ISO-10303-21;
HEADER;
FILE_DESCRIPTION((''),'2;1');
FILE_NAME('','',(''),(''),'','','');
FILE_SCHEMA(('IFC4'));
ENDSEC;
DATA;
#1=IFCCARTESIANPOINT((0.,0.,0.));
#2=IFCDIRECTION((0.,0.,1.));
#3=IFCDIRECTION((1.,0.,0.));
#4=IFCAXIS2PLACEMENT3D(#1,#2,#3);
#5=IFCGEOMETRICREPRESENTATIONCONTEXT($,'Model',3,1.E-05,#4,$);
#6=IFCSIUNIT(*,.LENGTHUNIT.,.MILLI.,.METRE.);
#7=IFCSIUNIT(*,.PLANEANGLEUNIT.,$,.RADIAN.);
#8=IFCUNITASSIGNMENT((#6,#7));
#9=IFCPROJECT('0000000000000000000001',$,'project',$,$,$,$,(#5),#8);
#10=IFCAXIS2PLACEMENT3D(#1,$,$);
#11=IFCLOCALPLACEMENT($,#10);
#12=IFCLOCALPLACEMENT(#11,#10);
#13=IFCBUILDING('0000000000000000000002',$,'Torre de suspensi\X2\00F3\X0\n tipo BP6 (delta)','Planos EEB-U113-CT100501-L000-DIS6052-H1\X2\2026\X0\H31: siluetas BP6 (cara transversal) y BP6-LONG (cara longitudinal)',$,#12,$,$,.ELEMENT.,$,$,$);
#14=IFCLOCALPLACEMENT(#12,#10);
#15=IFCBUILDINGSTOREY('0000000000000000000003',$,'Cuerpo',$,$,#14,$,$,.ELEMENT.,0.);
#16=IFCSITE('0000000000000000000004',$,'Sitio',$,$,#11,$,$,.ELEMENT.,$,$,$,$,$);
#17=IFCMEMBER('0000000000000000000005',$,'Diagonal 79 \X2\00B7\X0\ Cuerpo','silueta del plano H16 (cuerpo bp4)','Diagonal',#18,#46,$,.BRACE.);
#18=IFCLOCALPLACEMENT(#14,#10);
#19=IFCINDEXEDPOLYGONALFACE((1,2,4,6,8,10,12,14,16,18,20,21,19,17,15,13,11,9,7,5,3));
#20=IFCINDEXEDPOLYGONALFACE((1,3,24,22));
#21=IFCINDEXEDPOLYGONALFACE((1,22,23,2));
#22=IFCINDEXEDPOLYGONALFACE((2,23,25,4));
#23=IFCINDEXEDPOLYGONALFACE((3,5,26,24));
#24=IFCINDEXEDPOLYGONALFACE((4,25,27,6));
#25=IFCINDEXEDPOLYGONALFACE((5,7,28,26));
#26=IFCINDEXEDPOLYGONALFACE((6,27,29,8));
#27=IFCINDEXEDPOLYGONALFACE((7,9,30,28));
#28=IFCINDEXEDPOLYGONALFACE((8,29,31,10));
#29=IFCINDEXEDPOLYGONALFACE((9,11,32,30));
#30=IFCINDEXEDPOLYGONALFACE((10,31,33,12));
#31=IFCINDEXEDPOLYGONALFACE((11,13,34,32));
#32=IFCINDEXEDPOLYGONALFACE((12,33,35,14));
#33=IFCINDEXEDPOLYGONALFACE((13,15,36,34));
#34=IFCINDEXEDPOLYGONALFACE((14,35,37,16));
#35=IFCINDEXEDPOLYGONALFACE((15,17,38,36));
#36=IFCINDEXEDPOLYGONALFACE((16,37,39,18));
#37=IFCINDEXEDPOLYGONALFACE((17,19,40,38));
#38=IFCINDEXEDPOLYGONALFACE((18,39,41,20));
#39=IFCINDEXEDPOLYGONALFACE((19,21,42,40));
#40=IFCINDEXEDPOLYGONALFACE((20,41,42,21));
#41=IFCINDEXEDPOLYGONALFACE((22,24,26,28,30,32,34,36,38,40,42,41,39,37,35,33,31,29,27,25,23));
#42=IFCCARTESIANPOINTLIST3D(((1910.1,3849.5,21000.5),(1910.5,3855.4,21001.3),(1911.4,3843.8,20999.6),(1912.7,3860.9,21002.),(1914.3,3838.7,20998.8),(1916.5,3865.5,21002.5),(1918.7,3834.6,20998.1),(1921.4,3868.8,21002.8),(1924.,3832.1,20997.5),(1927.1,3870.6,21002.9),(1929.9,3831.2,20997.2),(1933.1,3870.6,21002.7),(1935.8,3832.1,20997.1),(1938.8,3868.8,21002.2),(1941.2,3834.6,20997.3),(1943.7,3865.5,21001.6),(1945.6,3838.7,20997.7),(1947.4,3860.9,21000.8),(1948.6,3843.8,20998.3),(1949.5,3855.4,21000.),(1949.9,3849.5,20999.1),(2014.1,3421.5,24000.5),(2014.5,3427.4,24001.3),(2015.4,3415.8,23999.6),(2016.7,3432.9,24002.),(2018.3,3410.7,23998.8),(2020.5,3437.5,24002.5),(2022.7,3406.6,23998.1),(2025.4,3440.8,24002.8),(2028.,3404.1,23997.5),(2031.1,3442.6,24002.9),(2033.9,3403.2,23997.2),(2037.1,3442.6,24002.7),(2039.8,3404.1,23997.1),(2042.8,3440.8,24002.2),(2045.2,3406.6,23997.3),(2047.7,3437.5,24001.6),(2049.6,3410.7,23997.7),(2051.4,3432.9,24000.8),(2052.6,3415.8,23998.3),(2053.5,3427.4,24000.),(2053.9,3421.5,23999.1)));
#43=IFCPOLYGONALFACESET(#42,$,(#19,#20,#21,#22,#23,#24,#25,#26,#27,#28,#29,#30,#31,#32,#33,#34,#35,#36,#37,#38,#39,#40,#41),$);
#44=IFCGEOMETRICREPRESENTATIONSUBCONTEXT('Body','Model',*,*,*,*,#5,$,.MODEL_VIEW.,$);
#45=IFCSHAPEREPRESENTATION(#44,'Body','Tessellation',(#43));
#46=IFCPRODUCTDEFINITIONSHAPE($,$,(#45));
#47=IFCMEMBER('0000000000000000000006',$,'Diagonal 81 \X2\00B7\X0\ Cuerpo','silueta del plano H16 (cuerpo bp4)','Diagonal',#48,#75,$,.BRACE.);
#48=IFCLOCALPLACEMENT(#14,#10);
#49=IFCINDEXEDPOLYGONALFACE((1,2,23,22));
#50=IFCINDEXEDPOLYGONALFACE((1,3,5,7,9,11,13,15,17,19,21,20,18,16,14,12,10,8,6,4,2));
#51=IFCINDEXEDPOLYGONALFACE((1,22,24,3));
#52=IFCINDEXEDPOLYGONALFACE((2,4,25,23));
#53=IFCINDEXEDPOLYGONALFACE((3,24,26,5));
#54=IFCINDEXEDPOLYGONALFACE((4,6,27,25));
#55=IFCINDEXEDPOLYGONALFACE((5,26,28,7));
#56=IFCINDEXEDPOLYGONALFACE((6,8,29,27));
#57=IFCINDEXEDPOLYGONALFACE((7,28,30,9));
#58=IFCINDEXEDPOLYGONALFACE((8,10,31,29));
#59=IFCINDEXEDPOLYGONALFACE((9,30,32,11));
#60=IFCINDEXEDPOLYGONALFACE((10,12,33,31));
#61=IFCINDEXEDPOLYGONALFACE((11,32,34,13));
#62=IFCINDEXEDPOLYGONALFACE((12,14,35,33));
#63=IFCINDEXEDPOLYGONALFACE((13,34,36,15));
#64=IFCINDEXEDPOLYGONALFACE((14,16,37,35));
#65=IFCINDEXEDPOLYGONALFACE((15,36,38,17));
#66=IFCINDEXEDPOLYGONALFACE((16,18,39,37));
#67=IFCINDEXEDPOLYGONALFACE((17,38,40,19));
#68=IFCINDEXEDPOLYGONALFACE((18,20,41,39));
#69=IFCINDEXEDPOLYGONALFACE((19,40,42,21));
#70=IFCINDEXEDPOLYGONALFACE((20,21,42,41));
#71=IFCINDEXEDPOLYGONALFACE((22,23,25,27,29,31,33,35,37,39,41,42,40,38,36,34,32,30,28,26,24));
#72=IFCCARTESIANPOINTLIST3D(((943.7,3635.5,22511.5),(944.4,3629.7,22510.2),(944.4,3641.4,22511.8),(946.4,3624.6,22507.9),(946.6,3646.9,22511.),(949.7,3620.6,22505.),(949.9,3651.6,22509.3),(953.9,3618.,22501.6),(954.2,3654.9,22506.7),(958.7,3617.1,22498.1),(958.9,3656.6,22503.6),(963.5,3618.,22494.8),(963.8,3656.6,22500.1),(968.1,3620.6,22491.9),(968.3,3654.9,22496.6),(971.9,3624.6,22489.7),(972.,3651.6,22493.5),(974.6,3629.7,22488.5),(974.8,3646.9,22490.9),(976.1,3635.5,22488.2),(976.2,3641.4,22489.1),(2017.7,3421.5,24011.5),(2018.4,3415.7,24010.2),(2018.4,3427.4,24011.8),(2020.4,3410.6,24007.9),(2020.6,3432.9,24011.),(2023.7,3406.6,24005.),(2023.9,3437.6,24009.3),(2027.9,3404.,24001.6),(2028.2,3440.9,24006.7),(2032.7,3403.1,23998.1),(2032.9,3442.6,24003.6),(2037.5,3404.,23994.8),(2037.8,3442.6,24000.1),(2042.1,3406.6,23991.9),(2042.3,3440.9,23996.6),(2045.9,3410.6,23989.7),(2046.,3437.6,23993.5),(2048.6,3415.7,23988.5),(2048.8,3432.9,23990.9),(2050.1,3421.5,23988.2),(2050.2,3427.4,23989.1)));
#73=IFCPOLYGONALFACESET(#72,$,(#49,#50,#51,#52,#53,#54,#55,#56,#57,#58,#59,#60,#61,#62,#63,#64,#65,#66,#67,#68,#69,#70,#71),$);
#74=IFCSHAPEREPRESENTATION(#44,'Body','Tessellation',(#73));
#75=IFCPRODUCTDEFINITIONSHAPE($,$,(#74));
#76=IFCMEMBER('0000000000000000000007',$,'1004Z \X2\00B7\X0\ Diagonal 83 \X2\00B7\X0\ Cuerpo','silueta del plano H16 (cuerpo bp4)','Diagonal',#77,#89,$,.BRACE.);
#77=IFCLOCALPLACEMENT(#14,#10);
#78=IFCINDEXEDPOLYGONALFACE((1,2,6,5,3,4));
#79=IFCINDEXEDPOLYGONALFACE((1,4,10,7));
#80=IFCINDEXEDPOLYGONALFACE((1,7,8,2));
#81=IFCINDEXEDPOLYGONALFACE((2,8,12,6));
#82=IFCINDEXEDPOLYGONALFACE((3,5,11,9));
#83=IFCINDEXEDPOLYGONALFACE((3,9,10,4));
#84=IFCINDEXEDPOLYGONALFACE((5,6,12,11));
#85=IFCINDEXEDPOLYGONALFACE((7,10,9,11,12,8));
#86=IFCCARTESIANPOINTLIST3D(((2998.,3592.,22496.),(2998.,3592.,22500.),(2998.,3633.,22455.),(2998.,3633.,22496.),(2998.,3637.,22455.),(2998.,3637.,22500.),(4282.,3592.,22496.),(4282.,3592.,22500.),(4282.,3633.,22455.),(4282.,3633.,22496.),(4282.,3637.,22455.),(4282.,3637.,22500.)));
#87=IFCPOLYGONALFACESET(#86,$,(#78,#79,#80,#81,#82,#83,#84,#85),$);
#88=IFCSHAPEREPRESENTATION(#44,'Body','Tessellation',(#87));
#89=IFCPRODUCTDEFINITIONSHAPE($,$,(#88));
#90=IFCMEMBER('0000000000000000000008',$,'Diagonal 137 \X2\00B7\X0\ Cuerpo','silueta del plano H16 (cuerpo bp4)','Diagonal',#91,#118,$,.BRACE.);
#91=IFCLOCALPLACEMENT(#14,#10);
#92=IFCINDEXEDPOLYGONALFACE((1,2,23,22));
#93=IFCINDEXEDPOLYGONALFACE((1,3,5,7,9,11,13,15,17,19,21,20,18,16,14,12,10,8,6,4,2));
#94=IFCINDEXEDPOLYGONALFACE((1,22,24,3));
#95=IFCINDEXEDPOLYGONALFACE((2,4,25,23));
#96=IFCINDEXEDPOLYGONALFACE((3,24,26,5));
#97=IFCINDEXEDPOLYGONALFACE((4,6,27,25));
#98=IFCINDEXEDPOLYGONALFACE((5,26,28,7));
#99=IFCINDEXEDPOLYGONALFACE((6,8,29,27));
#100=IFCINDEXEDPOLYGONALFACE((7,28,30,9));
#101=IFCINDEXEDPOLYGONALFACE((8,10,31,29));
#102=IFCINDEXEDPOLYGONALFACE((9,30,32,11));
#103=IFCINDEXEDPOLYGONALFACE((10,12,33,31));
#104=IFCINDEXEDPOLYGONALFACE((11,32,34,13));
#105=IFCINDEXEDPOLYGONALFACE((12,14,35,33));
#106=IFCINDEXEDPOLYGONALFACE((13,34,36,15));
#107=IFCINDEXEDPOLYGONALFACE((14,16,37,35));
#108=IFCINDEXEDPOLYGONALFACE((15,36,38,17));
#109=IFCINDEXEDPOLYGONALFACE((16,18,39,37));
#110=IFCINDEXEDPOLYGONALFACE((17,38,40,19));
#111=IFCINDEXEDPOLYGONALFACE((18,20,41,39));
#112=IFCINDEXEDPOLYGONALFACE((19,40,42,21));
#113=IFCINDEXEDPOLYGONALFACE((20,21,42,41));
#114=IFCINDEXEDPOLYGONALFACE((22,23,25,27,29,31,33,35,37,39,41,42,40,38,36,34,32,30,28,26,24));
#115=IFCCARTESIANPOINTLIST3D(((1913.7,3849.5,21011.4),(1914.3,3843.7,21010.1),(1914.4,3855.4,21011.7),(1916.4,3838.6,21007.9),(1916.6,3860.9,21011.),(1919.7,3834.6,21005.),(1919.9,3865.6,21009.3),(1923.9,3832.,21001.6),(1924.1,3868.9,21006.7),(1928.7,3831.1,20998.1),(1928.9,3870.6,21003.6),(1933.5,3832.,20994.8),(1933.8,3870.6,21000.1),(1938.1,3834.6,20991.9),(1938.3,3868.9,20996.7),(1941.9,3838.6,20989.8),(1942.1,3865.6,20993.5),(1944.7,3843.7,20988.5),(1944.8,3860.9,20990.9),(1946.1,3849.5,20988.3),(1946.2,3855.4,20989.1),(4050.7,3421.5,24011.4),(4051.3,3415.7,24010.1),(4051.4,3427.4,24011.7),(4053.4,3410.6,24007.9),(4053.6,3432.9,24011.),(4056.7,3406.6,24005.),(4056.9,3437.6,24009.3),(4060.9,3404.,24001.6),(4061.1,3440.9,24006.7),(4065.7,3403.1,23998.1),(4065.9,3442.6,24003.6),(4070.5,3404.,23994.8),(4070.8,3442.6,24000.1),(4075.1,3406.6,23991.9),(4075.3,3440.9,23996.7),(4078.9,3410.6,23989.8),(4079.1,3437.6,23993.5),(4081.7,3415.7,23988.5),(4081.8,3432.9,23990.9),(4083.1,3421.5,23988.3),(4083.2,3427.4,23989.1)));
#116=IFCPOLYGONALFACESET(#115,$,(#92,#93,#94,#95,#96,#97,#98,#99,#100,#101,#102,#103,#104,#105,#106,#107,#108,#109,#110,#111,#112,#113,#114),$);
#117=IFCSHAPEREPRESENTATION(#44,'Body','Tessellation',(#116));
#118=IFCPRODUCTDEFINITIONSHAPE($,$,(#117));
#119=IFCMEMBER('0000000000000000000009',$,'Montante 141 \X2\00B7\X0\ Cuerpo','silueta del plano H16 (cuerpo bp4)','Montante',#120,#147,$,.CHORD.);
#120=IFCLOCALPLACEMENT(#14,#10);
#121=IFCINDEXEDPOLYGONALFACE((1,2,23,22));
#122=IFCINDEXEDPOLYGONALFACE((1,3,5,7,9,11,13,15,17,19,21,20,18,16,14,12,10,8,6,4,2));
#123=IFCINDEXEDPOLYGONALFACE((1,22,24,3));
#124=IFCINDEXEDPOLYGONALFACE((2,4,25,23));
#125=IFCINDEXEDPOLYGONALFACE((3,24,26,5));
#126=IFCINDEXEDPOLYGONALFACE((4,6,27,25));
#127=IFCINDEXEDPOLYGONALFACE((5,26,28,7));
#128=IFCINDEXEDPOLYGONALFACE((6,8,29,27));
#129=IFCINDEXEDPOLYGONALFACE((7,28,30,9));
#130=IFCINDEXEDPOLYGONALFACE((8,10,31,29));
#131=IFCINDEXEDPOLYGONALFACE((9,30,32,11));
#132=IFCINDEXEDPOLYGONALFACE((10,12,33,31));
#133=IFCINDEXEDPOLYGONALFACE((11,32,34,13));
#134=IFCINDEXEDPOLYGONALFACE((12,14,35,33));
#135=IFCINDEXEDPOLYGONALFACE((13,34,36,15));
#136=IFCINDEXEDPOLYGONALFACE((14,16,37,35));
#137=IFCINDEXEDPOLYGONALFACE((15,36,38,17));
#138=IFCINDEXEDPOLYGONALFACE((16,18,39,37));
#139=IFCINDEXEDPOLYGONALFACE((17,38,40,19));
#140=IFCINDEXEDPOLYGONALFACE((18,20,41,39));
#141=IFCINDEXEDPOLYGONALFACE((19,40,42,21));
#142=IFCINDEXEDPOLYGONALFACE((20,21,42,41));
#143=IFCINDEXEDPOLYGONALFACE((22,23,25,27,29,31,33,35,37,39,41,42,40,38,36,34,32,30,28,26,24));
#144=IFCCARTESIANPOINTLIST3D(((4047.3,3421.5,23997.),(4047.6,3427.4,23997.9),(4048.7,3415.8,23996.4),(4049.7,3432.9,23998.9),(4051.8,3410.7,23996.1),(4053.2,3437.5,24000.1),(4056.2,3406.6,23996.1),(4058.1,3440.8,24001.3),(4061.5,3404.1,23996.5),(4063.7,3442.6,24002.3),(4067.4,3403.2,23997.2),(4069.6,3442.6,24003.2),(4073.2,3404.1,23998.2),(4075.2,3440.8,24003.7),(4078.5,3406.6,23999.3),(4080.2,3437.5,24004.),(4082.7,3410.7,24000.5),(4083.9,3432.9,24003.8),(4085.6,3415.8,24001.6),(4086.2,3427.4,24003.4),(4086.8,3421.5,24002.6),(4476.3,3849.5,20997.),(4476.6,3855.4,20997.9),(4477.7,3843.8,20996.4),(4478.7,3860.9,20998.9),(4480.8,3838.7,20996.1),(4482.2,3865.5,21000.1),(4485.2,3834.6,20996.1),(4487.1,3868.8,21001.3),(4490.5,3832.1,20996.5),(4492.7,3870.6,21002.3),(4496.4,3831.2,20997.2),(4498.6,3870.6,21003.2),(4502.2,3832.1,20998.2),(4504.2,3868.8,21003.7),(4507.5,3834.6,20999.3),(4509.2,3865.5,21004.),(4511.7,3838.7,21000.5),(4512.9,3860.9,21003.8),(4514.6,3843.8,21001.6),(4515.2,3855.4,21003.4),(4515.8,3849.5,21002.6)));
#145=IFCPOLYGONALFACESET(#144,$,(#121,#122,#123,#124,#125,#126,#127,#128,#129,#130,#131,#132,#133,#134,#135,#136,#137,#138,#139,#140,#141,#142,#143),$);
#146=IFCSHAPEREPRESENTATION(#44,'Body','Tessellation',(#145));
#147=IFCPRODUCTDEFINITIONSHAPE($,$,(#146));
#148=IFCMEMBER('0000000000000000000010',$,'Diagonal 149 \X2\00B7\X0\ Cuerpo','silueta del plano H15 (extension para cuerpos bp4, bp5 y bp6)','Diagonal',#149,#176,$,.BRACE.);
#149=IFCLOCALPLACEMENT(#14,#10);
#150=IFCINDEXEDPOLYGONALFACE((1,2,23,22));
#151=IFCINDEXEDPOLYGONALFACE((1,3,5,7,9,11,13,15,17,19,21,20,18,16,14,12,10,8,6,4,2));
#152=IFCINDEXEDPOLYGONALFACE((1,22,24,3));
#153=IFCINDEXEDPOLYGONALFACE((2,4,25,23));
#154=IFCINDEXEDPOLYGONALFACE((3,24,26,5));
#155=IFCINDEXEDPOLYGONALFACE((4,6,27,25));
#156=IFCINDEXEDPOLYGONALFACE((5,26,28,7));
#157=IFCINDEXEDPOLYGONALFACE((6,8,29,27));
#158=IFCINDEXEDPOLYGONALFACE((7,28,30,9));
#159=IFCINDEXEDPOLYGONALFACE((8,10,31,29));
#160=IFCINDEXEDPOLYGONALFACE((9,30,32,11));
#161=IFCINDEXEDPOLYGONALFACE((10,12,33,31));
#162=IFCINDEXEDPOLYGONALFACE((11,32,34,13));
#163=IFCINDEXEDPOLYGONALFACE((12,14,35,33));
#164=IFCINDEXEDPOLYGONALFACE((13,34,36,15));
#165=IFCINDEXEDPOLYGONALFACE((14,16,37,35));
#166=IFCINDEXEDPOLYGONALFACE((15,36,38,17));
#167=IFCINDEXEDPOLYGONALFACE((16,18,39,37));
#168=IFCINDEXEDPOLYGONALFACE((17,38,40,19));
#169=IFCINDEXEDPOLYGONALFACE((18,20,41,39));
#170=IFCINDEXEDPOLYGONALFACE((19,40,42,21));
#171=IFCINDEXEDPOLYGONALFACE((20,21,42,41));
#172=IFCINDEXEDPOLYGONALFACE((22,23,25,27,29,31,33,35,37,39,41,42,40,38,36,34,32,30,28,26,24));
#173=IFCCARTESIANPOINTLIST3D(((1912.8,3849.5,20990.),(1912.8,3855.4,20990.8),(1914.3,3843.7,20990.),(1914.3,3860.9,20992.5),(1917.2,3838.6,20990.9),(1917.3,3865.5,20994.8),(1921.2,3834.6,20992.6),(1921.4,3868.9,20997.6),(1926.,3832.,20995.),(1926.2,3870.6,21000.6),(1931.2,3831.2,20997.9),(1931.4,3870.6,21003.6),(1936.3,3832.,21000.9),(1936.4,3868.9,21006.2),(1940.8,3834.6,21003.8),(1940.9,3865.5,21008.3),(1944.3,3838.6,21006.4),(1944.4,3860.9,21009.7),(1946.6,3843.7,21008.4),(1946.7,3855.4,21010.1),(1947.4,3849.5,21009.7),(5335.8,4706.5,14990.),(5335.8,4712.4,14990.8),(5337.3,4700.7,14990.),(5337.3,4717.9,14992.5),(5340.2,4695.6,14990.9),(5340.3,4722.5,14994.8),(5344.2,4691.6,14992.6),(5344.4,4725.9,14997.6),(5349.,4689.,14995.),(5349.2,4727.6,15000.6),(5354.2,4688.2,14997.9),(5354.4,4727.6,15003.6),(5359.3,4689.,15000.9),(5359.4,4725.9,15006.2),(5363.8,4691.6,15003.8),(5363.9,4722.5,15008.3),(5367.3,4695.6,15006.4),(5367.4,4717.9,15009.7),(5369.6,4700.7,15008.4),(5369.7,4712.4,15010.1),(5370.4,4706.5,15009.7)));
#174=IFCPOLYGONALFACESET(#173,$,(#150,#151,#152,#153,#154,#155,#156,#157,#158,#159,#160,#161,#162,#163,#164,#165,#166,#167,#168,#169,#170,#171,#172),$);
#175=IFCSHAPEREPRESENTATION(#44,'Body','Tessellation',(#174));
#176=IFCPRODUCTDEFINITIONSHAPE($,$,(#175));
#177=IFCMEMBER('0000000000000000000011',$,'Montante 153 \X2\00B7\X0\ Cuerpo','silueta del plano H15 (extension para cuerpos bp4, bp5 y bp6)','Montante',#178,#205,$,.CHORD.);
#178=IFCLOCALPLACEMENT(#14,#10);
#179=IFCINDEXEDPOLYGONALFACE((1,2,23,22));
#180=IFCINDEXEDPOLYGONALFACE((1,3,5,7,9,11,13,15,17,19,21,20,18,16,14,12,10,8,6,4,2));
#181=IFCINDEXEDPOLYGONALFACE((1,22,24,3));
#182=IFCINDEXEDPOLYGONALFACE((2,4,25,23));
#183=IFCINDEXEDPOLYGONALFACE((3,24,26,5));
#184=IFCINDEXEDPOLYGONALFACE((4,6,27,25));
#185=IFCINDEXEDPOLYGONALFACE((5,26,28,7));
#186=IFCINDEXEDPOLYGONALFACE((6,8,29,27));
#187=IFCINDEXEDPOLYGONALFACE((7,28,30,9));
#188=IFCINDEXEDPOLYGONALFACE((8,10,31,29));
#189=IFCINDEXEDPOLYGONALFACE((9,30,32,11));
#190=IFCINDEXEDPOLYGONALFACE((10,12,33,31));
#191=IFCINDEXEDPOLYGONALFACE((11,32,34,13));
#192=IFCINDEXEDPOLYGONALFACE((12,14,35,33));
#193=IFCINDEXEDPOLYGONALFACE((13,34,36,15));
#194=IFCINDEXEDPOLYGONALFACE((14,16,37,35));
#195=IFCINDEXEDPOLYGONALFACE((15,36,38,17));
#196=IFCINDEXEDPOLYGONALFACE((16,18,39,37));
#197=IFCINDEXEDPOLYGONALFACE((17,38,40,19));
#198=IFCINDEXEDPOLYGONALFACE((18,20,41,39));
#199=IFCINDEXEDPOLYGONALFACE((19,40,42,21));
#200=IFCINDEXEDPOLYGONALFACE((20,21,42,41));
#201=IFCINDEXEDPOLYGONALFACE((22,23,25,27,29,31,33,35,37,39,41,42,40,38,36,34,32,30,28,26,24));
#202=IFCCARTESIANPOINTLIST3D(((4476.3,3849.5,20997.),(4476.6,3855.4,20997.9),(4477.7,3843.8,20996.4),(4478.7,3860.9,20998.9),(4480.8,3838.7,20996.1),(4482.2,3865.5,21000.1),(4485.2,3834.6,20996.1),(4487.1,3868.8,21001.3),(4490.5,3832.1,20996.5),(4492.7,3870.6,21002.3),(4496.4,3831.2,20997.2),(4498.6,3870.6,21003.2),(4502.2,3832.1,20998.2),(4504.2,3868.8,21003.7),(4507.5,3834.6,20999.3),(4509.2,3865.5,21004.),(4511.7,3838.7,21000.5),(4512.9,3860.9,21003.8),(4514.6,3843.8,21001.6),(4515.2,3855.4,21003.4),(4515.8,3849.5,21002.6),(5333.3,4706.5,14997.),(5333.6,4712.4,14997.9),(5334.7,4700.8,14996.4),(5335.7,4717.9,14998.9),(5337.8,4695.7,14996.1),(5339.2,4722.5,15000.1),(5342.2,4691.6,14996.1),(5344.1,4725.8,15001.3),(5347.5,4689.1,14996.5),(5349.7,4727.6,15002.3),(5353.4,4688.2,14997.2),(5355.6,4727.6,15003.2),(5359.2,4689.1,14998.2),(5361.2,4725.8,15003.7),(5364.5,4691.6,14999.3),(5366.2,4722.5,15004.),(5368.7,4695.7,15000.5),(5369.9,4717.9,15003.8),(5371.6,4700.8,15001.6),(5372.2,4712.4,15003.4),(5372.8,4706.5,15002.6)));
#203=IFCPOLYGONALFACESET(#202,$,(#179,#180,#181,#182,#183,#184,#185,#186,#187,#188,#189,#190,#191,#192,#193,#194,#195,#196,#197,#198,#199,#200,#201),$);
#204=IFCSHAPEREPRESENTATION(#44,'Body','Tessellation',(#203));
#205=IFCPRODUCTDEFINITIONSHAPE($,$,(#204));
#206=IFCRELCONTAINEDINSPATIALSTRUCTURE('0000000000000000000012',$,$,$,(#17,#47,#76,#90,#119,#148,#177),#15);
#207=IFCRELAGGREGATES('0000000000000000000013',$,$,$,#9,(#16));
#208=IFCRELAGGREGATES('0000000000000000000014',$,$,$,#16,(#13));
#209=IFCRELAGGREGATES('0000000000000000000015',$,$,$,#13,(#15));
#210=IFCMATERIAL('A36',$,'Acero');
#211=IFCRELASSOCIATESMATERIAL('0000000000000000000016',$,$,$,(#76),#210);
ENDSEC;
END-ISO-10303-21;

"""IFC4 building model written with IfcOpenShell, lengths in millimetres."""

from ifc_helpers import new_model, si_unit, frame, frame_2d, origin, origin_with_axes, place, context, subcontext, project, spatial, circle, l_section, extrude, material, element, save


model = new_model("IFC4")

# Units and contexts
model_context = context("Model", 3, precision=1e-05, world=origin_with_axes())
body_context = subcontext(model_context, "Body", "Model", "MODEL_VIEW")
ifc_project = project(units=[si_unit("LENGTHUNIT", "METRE", prefix="MILLI"), si_unit("PLANEANGLEUNIT", "RADIAN")], contexts=[model_context])

# Site, building, storey
site_placement = place(None, origin())
site = spatial("IfcSite", under=ifc_project, at=site_placement, Name="Sitio", CompositionType="ELEMENT")
building_placement = place(site_placement, origin())
building = spatial("IfcBuilding", under=site, at=building_placement, Name="Torre de suspensión tipo BP6 (delta)", Description="Planos EEB-U113-CT100501-L000-DIS6052-H1…H31: siluetas BP6 (cara transversal) y BP6-LONG (cara longitudinal)", CompositionType="ELEMENT")
storey_placement = place(building_placement, origin())
storey = spatial("IfcBuildingStorey", under=building, at=storey_placement, Name="Cuerpo", CompositionType="ELEMENT", Elevation=0.0)

# Members
member_1_placement = place(storey_placement, frame((1930.0, 3851.0, 21000.0), z_axis=(0.034299, -0.141153, 0.989393), x_axis=(-0.00489, -0.989988, -0.141069)))
element("IfcMember", 1, at=member_1_placement, inside=storey, Name="Diagonal 79 · Cuerpo", Description="silueta del plano H16 (cuerpo bp4)", ObjectType="Diagonal", PredefinedType="BRACE", context=body_context, shape_type="SweptSolid", body=[
    extrude(circle(Radius=20.0), None, (0.0, 0.0, 1.0), 3032.2),
])
member_2_placement = place(storey_placement, frame((2034.0, 3423.0, 24000.0), z_axis=(-0.578283, 0.115226, -0.807658), x_axis=(-0.06708, -0.993339, -0.093687)))
element("IfcMember", 2, at=member_2_placement, inside=storey, Name="Diagonal 81 · Cuerpo", Description="silueta del plano H16 (cuerpo bp4)", ObjectType="Diagonal", PredefinedType="BRACE", context=body_context, shape_type="SweptSolid", body=[
    extrude(circle(Radius=20.0), None, (0.0, 0.0, 1.0), 1857.2),
])
ifc_material = material(Name="A36", Category="Acero")
member_3_placement = place(storey_placement, frame((2998.0, 3637.0, 22500.0), z_axis=(1.0, 0.0, 0.0), x_axis=(0.0, -1.0, 0.0)))
element("IfcMember", 3, at=member_3_placement, inside=storey, material=ifc_material, Name="1004Z · Diagonal 83 · Cuerpo", Description="silueta del plano H16 (cuerpo bp4)", ObjectType="Diagonal", PredefinedType="BRACE", context=body_context, shape_type="SweptSolid", body=[
    extrude(l_section(Depth=45.0, Width=45.0, Thickness=4.0, at=frame_2d((22.5, 22.5))), None, (0.0, 0.0, 1.0), 1284.0),
])
member_4_placement = place(storey_placement, frame((4067.0, 3423.0, 24000.0), z_axis=(-0.576307, 0.115423, -0.809041), x_axis=(-0.066967, -0.993316, -0.09401)))
element("IfcMember", 4, at=member_4_placement, inside=storey, Name="Diagonal 137 · Cuerpo", Description="silueta del plano H16 (cuerpo bp4)", ObjectType="Diagonal", PredefinedType="BRACE", context=body_context, shape_type="SweptSolid", body=[
    extrude(circle(Radius=20.0), None, (0.0, 0.0, 1.0), 3708.1),
])
member_5_placement = place(storey_placement, frame((4067.0, 3423.0, 24000.0), z_axis=(0.140169, 0.139842, -0.980202), x_axis=(0.019796, -0.990174, -0.138434)))
element("IfcMember", 5, at=member_5_placement, inside=storey, Name="Montante 141 · Cuerpo", Description="silueta del plano H16 (cuerpo bp4)", ObjectType="Montante", PredefinedType="CHORD", context=body_context, shape_type="SweptSolid", body=[
    extrude(circle(Radius=20.0), None, (0.0, 0.0, 1.0), 3060.6),
])
member_6_placement = place(storey_placement, frame((1930.0, 3851.0, 21000.0), z_axis=(0.491761, 0.12312, -0.861982), x_axis=(0.06101, -0.992392, -0.106941)))
element("IfcMember", 6, at=member_6_placement, inside=storey, Name="Diagonal 149 · Cuerpo", Description="silueta del plano H15 (extension para cuerpos bp4, bp5 y bp6)", ObjectType="Diagonal", PredefinedType="BRACE", context=body_context, shape_type="SweptSolid", body=[
    extrude(circle(Radius=20.0), None, (0.0, 0.0, 1.0), 6960.7),
])
member_7_placement = place(storey_placement, frame((4496.0, 3851.0, 21000.0), z_axis=(0.140006, 0.140006, -0.980202), x_axis=(0.019797, -0.990151, -0.138599)))
element("IfcMember", 7, at=member_7_placement, inside=storey, Name="Montante 153 · Cuerpo", Description="silueta del plano H15 (extension para cuerpos bp4, bp5 y bp6)", ObjectType="Montante", PredefinedType="CHORD", context=body_context, shape_type="SweptSolid", body=[
    extrude(circle(Radius=20.0), None, (0.0, 0.0, 1.0), 6121.2),
])

save(model, "model.ifc")
